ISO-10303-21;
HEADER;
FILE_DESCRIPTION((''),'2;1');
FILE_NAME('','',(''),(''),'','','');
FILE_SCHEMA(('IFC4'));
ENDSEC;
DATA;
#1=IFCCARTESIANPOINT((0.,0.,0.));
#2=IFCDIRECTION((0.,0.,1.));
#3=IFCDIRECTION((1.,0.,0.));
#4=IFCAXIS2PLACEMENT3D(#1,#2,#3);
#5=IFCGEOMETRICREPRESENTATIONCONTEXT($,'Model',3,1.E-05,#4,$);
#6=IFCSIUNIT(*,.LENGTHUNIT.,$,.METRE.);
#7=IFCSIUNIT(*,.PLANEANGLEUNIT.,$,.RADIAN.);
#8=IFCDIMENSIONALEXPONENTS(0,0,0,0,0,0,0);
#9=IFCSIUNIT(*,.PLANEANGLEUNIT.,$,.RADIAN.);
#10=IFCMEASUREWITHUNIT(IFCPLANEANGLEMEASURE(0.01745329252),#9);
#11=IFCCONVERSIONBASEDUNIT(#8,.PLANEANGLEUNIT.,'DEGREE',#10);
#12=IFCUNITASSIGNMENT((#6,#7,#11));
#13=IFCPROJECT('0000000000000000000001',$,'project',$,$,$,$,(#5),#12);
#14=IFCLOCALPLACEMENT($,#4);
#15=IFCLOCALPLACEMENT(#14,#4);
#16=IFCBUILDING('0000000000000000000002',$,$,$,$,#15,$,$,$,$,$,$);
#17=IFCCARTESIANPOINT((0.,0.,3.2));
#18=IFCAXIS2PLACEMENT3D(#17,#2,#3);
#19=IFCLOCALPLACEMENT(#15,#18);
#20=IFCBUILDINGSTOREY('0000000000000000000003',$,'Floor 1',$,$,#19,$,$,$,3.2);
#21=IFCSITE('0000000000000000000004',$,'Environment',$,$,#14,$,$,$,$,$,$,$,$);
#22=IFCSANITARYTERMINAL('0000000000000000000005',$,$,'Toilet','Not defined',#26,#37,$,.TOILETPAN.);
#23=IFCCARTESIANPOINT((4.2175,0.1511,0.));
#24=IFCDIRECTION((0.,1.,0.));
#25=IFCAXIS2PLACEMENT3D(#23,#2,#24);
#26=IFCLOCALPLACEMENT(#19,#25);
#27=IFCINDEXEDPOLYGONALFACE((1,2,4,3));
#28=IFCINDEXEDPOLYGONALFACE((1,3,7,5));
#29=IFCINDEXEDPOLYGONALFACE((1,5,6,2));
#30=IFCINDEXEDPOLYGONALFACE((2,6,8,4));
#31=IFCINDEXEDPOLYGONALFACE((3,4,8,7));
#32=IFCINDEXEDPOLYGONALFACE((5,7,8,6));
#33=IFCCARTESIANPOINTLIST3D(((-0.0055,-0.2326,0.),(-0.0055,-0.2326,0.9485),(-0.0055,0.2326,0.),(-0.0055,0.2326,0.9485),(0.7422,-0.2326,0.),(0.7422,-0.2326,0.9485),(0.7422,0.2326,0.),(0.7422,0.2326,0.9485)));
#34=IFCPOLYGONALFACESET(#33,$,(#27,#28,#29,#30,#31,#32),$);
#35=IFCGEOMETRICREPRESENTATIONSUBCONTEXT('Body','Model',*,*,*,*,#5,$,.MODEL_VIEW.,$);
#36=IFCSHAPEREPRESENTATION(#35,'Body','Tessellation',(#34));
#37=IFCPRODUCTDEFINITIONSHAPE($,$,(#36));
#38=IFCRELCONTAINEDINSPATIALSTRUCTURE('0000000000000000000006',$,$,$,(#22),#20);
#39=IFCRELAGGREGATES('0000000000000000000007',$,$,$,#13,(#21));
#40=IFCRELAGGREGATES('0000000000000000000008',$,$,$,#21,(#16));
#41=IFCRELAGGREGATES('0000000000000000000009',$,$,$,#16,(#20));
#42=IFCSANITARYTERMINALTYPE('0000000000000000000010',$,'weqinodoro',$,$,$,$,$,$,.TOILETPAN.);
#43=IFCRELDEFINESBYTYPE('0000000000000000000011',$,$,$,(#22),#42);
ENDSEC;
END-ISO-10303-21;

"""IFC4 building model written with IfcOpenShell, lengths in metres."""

from ifc_helpers import new_model, entity, si_unit, converted_unit, frame, origin_with_axes, place, context, subcontext, project, spatial, polyline, outline, extrude, source, transform, mapped, type_object, element, save


model = new_model("IFC4")

# Units and contexts
model_context = context("Model", 3, precision=1e-05, world=origin_with_axes())
body_context = subcontext(model_context, "Body", "Model", "MODEL_VIEW")
ifc_project = project(units=[si_unit("LENGTHUNIT", "METRE"), si_unit("PLANEANGLEUNIT", "RADIAN"), converted_unit("PLANEANGLEUNIT", "DEGREE", entity("IfcPlaneAngleMeasure", 0.01745329252), si_unit("PLANEANGLEUNIT", "RADIAN"), dimensions=[0, 0, 0, 0, 0, 0, 0])], contexts=[model_context])

# Site, building, storey
site_placement = place(None, origin_with_axes())
site = spatial("IfcSite", under=ifc_project, at=site_placement, Name="Environment")
building_placement = place(site_placement, origin_with_axes())
building = spatial("IfcBuilding", under=site, at=building_placement)
storey_placement = place(building_placement, frame((0.0, 0.0, 3.2), z_axis=(0.0, 0.0, 1.0), x_axis=(1.0, 0.0, 0.0)))
storey = spatial("IfcBuildingStorey", under=building, at=storey_placement, Name="Floor 1", Elevation=3.2)

# Sanitary terminal
sanitary_terminal_type_1 = type_object("IfcSanitaryTerminalType", Name="weqinodoro", PredefinedType="TOILETPAN")
shared_shape_1 = source(origin_with_axes(), body_context, "Body", "SolidModel", [
    extrude(outline(polyline([(-0.0055, -0.2326), (0.7422, -0.2326), (0.7422, 0.2326), (-0.0055, 0.2326), (-0.0055, -0.2326)])), origin_with_axes(), (0.0, 0.0, 1.0), 0.9485),
])
sanitary_terminal_1_placement = place(storey_placement, frame((4.2175, 0.1511, 0.0), z_axis=(0.0, 0.0, 1.0), x_axis=(0.0, 1.0, 0.0)))
element("IfcSanitaryTerminal", 1, at=sanitary_terminal_1_placement, inside=storey, type_object=sanitary_terminal_type_1, Description="Toilet", ObjectType="Not defined", PredefinedType="TOILETPAN", context=body_context, shape_type="MappedRepresentation", body=[
    mapped(shared_shape_1, transform((0.0, 0.0, 0.0), x_axis=(1.0, 0.0, 0.0), y_axis=(0.0, 1.0, 0.0), z_axis=(0.0, 0.0, 1.0))),
])

save(model, "model.ifc")
